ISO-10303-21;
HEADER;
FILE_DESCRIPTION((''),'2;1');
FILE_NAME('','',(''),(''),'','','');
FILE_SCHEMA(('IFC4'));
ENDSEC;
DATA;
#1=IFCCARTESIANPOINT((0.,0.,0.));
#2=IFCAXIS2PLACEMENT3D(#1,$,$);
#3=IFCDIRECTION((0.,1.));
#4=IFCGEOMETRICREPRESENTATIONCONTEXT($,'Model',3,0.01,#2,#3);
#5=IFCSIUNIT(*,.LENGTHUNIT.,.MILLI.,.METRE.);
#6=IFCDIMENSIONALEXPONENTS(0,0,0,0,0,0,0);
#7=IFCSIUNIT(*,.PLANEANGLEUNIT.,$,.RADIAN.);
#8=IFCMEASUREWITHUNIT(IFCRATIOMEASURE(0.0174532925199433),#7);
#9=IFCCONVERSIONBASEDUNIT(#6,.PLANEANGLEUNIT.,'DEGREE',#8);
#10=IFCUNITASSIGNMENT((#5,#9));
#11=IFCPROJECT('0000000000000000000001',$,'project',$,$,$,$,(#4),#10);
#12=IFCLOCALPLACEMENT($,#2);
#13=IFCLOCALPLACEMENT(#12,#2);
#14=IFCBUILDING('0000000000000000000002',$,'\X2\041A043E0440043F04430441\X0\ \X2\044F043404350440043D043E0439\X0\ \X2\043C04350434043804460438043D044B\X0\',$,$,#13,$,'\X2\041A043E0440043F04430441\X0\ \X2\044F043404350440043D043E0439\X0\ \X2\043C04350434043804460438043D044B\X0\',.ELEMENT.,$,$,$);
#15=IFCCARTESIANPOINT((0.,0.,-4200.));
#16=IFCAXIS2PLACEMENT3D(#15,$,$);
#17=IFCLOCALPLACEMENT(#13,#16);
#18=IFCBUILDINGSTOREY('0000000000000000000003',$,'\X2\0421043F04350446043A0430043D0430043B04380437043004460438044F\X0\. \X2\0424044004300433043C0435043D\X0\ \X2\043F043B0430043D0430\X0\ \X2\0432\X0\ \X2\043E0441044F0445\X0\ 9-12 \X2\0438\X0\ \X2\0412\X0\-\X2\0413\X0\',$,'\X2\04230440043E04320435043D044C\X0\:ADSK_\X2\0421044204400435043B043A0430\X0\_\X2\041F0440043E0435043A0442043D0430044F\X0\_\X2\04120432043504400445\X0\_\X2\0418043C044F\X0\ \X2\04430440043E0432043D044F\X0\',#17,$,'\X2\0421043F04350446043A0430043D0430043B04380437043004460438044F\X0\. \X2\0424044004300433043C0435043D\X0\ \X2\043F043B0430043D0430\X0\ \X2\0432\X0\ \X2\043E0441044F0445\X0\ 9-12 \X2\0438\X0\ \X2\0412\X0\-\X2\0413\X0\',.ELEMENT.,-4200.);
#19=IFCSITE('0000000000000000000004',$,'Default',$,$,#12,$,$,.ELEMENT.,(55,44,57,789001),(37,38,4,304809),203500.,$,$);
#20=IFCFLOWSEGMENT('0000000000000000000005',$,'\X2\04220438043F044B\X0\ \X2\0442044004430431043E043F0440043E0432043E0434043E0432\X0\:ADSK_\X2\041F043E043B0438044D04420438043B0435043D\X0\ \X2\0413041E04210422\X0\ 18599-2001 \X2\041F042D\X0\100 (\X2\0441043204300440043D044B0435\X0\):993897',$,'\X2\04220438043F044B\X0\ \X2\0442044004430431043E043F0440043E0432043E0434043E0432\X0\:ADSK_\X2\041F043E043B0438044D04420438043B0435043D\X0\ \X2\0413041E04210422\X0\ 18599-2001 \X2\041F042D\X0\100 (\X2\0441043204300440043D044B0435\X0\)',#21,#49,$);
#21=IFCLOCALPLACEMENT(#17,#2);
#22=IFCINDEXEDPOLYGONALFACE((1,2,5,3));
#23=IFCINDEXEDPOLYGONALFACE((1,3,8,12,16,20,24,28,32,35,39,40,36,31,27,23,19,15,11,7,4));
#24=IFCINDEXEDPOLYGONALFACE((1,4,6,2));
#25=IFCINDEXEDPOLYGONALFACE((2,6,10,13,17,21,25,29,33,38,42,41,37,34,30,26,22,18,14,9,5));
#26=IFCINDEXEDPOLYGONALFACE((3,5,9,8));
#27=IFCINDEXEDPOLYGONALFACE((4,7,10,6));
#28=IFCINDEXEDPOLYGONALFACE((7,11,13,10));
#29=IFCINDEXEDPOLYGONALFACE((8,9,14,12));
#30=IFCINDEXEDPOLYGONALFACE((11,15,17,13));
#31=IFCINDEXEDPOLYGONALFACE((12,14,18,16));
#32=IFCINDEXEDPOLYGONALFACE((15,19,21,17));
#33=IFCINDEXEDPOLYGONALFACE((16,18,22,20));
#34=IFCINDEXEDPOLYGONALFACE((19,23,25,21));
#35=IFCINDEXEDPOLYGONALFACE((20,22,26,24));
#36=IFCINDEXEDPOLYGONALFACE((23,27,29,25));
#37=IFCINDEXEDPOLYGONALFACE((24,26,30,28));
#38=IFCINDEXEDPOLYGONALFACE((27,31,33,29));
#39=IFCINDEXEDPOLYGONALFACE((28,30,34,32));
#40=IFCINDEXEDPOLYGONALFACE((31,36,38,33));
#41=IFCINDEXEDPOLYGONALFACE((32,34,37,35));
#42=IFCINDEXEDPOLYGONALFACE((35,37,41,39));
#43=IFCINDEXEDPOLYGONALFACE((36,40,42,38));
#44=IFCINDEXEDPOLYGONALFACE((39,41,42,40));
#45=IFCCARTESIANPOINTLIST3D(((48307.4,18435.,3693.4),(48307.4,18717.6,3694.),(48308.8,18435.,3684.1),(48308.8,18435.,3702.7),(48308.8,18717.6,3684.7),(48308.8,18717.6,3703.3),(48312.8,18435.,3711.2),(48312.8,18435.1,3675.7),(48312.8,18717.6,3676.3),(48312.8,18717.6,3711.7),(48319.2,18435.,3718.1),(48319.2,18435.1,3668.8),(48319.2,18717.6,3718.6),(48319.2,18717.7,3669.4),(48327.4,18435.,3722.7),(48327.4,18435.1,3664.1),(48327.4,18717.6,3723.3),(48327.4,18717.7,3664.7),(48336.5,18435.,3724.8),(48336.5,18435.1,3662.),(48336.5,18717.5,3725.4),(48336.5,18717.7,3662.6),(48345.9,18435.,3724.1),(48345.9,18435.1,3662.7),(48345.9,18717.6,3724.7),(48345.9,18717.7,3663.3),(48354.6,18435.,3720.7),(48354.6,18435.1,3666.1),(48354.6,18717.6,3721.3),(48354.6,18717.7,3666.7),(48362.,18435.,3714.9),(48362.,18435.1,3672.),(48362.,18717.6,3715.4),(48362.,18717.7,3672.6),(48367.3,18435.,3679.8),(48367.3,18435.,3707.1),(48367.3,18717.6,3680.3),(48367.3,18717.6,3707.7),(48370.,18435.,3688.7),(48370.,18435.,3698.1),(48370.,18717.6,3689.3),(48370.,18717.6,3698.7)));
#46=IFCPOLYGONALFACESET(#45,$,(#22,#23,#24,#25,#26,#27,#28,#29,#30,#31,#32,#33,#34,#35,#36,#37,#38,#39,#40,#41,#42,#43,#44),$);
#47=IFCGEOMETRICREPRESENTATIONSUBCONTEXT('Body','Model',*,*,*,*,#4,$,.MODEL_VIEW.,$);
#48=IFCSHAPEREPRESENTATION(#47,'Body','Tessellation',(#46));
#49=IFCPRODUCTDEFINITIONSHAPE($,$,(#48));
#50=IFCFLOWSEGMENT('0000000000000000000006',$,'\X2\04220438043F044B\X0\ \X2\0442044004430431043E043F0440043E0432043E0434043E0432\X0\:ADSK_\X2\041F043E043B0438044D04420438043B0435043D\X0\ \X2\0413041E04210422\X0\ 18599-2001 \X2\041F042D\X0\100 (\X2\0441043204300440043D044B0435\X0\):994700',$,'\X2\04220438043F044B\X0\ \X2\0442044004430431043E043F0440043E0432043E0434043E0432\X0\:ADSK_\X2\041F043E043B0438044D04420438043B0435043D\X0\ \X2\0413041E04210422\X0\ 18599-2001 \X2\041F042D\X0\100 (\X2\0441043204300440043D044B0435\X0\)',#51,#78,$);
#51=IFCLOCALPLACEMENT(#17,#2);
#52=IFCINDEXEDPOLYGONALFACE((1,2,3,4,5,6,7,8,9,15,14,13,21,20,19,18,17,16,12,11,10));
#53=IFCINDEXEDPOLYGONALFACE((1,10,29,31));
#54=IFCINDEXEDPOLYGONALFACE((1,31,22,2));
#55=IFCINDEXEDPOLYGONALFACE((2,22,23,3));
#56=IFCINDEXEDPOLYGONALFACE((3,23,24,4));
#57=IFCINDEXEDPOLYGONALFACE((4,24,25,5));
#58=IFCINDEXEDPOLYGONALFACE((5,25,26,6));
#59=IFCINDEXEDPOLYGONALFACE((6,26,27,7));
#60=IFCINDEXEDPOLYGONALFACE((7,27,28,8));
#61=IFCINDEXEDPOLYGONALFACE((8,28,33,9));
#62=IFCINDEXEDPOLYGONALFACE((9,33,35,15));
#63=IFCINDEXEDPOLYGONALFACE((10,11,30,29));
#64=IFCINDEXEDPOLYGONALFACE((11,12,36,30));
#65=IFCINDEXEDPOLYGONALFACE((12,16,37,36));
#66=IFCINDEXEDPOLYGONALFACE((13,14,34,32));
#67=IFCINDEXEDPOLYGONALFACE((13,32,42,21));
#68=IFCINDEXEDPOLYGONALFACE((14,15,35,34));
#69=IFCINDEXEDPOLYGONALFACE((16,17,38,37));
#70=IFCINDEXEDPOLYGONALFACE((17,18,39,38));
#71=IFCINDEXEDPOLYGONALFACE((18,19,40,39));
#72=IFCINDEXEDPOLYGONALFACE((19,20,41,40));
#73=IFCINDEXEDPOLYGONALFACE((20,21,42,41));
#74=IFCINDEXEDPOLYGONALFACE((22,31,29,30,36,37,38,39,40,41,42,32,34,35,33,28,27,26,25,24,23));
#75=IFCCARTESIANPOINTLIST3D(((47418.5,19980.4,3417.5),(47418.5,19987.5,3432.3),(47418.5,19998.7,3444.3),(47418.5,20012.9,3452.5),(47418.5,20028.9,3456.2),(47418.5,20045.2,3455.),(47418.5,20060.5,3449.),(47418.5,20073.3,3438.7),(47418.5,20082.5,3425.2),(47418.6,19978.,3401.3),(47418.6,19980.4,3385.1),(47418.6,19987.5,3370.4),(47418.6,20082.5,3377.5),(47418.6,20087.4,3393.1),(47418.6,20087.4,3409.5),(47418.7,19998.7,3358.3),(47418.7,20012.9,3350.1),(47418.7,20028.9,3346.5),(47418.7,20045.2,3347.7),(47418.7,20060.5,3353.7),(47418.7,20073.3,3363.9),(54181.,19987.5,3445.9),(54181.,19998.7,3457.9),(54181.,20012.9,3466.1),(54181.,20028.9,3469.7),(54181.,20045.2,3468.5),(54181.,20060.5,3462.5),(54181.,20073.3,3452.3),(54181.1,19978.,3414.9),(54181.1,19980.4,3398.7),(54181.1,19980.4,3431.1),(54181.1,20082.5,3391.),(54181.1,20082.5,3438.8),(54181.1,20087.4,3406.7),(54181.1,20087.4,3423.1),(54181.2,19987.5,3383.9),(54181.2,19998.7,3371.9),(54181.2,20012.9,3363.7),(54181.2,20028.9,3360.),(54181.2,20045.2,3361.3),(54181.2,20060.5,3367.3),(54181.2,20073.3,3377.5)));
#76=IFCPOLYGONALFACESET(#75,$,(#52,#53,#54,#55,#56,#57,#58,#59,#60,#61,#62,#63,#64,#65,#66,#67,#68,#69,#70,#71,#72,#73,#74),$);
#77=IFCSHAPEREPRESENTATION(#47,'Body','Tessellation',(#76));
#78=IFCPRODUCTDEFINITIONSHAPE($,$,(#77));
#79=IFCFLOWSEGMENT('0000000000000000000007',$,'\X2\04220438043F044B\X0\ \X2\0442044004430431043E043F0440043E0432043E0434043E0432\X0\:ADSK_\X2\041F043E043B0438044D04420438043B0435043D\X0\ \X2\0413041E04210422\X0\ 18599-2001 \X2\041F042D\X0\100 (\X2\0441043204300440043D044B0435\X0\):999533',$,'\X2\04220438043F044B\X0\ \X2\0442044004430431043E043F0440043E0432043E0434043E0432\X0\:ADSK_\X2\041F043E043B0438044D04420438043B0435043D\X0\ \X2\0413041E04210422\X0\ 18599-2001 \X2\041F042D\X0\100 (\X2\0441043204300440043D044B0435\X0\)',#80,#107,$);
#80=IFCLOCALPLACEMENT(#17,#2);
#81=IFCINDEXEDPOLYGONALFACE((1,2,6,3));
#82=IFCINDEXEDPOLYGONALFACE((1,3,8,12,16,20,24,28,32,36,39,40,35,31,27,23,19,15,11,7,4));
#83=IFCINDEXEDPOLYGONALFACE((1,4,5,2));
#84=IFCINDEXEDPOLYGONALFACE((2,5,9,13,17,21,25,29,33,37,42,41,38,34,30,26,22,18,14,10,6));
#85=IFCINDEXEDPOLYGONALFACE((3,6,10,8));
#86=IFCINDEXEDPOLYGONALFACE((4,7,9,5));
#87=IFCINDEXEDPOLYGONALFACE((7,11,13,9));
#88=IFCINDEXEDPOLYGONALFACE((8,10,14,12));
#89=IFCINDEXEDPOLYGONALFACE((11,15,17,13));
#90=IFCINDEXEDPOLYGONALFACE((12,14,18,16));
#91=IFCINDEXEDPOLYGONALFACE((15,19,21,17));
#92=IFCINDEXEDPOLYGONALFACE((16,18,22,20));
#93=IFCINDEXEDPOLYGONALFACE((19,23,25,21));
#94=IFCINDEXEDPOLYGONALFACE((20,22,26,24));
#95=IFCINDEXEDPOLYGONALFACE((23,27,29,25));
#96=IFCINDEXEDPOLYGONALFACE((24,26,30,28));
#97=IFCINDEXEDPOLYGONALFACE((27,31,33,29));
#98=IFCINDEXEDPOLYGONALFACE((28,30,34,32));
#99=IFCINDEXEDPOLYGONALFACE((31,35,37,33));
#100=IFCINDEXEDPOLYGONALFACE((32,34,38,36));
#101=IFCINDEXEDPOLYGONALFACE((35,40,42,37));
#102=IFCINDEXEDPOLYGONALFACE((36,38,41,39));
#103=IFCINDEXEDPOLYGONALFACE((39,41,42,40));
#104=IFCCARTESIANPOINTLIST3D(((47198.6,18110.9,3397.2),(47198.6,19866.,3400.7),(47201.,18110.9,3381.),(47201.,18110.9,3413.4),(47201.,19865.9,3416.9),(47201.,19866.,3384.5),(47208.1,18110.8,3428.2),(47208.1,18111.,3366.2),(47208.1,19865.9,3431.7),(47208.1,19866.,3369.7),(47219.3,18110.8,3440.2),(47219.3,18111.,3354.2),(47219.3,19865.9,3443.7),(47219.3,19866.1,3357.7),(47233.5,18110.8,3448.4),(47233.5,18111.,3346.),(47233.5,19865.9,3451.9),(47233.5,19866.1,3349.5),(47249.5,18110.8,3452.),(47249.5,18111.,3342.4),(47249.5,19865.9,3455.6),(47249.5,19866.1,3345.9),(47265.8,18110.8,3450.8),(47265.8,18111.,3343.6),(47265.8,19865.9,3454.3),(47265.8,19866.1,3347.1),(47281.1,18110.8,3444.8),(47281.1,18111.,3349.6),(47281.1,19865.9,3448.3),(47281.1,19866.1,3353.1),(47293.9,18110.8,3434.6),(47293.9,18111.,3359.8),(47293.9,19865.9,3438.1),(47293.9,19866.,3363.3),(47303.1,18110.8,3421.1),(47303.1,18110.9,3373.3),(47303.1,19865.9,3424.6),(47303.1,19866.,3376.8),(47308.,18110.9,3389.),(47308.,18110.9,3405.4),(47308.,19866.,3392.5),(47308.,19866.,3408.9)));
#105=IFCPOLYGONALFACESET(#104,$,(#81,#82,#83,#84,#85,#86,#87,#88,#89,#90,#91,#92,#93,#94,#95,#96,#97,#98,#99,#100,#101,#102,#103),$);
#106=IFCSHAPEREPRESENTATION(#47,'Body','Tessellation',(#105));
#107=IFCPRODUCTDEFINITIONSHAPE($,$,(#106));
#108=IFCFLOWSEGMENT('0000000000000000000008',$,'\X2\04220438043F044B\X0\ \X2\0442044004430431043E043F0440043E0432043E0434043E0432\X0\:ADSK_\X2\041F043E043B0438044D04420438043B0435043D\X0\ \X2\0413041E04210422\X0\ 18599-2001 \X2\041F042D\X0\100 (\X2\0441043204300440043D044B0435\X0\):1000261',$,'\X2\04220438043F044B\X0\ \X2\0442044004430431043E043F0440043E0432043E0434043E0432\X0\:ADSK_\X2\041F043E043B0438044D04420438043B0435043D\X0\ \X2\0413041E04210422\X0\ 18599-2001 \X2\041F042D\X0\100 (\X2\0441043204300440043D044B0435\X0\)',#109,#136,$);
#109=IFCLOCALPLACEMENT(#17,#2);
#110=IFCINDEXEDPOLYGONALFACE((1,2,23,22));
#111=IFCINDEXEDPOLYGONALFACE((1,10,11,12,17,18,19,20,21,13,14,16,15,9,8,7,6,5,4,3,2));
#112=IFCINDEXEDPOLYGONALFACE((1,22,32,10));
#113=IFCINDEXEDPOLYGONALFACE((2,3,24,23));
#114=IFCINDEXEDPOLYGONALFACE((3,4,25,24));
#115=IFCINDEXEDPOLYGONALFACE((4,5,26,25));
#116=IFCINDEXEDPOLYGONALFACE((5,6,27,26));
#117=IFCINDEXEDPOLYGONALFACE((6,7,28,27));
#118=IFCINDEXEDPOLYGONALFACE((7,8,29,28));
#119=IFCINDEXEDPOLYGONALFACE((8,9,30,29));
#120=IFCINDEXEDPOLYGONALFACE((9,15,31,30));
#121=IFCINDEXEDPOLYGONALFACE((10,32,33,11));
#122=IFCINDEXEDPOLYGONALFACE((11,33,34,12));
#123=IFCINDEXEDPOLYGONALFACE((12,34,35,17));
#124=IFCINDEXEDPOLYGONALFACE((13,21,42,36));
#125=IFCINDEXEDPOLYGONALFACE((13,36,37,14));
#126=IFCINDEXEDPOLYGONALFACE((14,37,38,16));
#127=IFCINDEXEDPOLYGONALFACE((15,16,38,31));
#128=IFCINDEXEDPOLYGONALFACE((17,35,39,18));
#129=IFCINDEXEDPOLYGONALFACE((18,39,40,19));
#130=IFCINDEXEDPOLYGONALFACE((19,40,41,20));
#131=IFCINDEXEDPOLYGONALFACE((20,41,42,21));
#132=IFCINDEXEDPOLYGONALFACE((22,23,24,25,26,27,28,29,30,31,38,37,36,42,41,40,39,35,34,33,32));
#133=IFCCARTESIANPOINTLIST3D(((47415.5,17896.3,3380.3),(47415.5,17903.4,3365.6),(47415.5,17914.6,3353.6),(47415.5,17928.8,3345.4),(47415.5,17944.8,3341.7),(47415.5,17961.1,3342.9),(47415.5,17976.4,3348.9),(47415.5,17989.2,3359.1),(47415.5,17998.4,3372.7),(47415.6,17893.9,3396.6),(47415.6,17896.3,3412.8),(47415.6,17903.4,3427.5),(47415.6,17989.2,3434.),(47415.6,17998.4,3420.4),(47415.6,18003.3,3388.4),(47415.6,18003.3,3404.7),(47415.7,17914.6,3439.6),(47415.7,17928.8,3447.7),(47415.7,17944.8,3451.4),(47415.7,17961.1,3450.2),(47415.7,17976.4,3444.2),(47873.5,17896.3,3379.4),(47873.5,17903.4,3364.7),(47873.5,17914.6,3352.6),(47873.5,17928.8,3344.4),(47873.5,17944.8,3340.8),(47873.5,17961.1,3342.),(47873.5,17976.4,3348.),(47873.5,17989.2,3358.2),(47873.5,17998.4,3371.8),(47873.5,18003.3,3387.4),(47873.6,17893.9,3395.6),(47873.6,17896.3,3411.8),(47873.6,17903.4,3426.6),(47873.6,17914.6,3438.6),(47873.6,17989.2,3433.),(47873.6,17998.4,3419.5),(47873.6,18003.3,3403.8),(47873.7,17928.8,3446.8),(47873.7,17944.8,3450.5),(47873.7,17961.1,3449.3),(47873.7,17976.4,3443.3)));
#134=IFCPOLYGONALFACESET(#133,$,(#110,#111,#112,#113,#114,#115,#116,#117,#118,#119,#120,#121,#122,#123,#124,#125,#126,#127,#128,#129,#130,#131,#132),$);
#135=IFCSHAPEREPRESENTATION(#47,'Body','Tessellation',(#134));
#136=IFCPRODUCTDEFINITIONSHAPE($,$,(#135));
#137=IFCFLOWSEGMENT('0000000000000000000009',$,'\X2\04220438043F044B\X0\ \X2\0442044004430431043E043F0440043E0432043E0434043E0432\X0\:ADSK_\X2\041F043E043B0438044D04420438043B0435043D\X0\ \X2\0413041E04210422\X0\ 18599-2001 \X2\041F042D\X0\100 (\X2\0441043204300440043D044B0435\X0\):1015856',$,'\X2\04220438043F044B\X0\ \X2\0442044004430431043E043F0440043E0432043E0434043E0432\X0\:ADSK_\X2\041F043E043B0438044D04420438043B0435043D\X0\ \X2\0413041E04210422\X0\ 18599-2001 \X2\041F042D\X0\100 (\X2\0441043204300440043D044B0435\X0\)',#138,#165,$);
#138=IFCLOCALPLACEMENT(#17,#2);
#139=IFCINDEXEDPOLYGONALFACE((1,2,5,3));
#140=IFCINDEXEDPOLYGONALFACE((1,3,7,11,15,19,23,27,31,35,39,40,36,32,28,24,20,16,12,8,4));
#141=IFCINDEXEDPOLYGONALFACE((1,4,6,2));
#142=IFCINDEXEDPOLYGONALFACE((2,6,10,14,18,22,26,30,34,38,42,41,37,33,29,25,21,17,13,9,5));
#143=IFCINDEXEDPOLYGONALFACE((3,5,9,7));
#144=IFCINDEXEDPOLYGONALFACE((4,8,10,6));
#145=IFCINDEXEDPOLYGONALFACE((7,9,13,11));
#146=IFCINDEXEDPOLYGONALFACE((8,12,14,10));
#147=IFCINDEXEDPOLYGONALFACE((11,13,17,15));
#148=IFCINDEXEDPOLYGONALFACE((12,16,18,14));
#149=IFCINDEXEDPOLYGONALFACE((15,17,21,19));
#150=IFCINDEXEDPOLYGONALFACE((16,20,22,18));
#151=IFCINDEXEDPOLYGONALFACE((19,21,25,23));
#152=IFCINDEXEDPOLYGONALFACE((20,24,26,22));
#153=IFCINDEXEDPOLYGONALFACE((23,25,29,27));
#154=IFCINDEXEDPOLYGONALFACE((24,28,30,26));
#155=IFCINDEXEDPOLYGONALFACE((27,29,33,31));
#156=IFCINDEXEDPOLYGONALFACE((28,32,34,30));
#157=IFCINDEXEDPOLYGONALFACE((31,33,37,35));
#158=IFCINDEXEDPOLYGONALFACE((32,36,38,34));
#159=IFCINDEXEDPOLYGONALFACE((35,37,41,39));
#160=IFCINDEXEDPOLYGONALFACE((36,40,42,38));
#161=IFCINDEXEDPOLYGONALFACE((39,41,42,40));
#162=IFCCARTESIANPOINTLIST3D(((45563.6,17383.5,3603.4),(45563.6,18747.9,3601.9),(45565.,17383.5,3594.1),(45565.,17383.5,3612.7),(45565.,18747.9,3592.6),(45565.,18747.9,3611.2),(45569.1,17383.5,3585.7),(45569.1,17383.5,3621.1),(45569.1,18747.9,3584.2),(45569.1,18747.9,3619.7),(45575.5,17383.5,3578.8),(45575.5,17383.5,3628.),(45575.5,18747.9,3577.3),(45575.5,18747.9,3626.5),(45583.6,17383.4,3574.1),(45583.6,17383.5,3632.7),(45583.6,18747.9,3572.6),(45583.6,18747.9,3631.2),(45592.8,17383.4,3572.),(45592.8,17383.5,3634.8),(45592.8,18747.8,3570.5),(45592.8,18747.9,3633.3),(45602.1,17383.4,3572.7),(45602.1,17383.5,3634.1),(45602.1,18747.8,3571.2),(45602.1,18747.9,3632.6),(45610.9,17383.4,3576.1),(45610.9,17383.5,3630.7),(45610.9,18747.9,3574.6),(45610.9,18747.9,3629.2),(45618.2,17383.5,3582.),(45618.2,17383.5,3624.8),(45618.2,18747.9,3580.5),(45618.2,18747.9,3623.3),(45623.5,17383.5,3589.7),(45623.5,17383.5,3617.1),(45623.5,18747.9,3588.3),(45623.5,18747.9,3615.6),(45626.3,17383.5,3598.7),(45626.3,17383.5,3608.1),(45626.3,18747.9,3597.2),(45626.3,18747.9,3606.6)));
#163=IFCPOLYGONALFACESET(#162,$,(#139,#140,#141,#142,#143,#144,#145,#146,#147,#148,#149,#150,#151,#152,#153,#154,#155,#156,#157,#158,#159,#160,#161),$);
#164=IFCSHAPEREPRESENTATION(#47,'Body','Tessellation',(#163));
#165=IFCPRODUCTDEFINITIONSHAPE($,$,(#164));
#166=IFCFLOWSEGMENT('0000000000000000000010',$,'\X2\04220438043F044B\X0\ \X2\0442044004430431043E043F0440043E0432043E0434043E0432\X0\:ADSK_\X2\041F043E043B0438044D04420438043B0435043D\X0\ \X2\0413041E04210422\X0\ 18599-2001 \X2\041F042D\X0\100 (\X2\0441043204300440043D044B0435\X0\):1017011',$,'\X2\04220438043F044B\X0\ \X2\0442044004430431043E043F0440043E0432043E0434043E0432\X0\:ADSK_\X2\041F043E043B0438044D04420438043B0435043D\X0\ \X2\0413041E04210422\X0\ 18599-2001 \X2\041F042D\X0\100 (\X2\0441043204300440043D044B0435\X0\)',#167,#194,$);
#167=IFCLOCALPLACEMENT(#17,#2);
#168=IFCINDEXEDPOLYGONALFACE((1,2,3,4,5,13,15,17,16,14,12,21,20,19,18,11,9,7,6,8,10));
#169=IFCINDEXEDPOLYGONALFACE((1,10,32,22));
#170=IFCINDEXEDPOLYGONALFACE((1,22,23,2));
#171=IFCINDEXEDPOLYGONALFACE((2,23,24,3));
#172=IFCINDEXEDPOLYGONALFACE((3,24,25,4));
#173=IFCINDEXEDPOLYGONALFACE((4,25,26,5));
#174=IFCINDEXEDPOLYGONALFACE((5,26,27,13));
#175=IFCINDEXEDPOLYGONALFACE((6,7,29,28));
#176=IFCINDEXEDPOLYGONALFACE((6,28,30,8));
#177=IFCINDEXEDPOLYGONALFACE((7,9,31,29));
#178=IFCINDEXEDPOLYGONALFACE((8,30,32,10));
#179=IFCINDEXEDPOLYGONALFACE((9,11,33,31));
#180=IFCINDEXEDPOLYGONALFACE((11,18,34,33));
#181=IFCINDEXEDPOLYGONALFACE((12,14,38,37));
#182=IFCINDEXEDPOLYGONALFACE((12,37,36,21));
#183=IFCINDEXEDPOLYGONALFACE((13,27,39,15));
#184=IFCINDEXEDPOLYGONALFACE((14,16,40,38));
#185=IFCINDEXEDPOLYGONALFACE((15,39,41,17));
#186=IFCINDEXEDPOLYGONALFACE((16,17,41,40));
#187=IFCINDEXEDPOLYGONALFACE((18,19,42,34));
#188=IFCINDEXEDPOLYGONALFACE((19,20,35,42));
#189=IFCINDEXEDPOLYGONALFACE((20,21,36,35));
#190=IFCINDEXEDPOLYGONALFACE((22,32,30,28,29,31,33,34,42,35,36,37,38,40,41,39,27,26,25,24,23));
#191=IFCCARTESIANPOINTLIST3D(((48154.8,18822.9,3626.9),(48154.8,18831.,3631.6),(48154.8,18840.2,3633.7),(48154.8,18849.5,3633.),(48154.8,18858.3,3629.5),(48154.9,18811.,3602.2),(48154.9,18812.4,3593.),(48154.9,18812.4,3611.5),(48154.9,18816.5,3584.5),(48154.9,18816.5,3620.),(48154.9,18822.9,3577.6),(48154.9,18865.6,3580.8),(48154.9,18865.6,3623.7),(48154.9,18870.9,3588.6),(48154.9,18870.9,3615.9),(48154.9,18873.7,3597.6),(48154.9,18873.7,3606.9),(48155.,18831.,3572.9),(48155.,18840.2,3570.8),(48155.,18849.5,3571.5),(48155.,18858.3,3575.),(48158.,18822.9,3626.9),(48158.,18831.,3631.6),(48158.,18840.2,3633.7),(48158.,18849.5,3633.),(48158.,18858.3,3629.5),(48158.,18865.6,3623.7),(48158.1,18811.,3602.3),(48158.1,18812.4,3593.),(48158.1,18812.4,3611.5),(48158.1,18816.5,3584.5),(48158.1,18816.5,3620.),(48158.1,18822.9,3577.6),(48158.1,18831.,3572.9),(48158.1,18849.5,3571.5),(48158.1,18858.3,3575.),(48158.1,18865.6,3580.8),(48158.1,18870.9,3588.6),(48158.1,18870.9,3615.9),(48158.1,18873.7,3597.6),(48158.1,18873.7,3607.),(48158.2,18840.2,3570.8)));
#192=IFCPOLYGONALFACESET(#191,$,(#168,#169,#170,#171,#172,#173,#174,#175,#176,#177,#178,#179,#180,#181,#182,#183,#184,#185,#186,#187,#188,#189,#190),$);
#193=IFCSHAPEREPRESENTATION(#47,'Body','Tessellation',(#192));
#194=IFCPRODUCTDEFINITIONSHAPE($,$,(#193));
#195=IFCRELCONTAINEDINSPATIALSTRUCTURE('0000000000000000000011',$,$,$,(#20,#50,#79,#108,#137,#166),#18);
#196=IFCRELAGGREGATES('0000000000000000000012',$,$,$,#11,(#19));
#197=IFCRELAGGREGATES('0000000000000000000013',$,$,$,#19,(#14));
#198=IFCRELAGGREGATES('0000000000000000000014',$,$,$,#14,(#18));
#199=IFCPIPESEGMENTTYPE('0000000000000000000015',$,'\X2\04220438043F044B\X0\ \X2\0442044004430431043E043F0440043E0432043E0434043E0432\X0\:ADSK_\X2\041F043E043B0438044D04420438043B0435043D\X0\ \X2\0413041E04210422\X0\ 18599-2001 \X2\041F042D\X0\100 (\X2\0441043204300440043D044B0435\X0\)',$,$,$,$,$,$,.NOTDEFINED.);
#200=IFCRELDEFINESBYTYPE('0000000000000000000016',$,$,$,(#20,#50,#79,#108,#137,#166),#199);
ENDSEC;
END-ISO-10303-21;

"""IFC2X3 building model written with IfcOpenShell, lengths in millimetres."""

from ifc_helpers import new_model, entity, si_unit, converted_unit, direction, frame, frame_2d, origin, origin_2d_with_axis, place, context, subcontext, project, spatial, circle, extrude, type_object, element, save


model = new_model("IFC2X3")

# Units and contexts
model_context = context("Model", 3, precision=0.01, world=origin(), true_north=direction((0.0, 1.0)))
body_context = subcontext(model_context, "Body", "Model", "MODEL_VIEW")
ifc_project = project(units=[si_unit("LENGTHUNIT", "METRE", prefix="MILLI"), converted_unit("PLANEANGLEUNIT", "DEGREE", entity("IfcRatioMeasure", 0.0174532925199433), si_unit("PLANEANGLEUNIT", "RADIAN"), dimensions=[0, 0, 0, 0, 0, 0, 0])], contexts=[model_context])

# Site, building, storey
site_placement = place(None, frame((0.0, 0.0, 0.0)))
site = spatial("IfcSite", under=ifc_project, at=site_placement, Name="Default", CompositionType="ELEMENT", RefLatitude=(55, 44, 57, 789001), RefLongitude=(37, 38, 4, 304809), RefElevation=203500.0)
building_placement = place(site_placement, origin())
building = spatial("IfcBuilding", under=site, at=building_placement, Name="Корпус ядерной медицины", LongName="Корпус ядерной медицины", CompositionType="ELEMENT")
storey_placement = place(building_placement, frame((0.0, 0.0, -4200.0)))
storey = spatial("IfcBuildingStorey", under=building, at=storey_placement, Name="Спецканализация. Фрагмен плана в осях 9-12 и В-Г", ObjectType="Уровень:ADSK_Стрелка_Проектная_Вверх_Имя уровня", LongName="Спецканализация. Фрагмен плана в осях 9-12 и В-Г", CompositionType="ELEMENT", Elevation=-4200.0)

# Flow segments
pipe_segment_type = type_object("IfcPipeSegmentType", Name="Типы трубопроводов:ADSK_Полиэтилен ГОСТ 18599-2001 ПЭ100 (сварные)", PredefinedType="NOTDEFINED")
flow_segment_1_placement = place(storey_placement, frame((48305.8, 18435.0, 3660.3)))
element("IfcFlowSegment", 1, at=flow_segment_1_placement, inside=storey, type_object=pipe_segment_type, Name="Типы трубопроводов:ADSK_Полиэтилен ГОСТ 18599-2001 ПЭ100 (сварные):993897", ObjectType="Типы трубопроводов:ADSK_Полиэтилен ГОСТ 18599-2001 ПЭ100 (сварные)", context=body_context, shape_type="SweptSolid", body=[
    extrude(circle(Radius=31.5, at=frame_2d((0.0, 0.0), x_axis=(1.0, 0.0))), frame((33.1, 0.1, 33.1), z_axis=(-0.000004, 0.999998, 0.002042), x_axis=(-1.0, -0.000004, 0.0)), (0.0, 0.0, 1.0), 282.6),
])
flow_segment_2_placement = place(storey_placement, frame((47418.5, 19976.4, 3344.7)))
element("IfcFlowSegment", 2, at=flow_segment_2_placement, inside=storey, type_object=pipe_segment_type, Name="Типы трубопроводов:ADSK_Полиэтилен ГОСТ 18599-2001 ПЭ100 (сварные):994700", ObjectType="Типы трубопроводов:ADSK_Полиэтилен ГОСТ 18599-2001 ПЭ100 (сварные)", context=body_context, shape_type="SweptSolid", body=[
    extrude(circle(Radius=55.0, at=origin_2d_with_axis()), frame((0.1, 56.6, 56.6), z_axis=(0.999998, 0.0, 0.002004), x_axis=(0.0, -1.0, 0.0)), (0.0, 0.0, 1.0), 6762.5),
])
flow_segment_3_placement = place(storey_placement, frame((47197.0, 18110.8, 3340.6)))
element("IfcFlowSegment", 3, at=flow_segment_3_placement, inside=storey, type_object=pipe_segment_type, Name="Типы трубопроводов:ADSK_Полиэтилен ГОСТ 18599-2001 ПЭ100 (сварные):999533", ObjectType="Типы трубопроводов:ADSK_Полиэтилен ГОСТ 18599-2001 ПЭ100 (сварные)", context=body_context, shape_type="SweptSolid", body=[
    extrude(circle(Radius=55.0, at=origin_2d_with_axis()), frame((56.6, 0.1, 56.6), z_axis=(0.000001, 0.999998, 0.002), x_axis=(-1.0, 0.000001, 0.0)), (0.0, 0.0, 1.0), 1755.1),
])
flow_segment_4_placement = place(storey_placement, frame((47415.5, 17892.3, 3339.0)))
element("IfcFlowSegment", 4, at=flow_segment_4_placement, inside=storey, type_object=pipe_segment_type, Name="Типы трубопроводов:ADSK_Полиэтилен ГОСТ 18599-2001 ПЭ100 (сварные):1000261", ObjectType="Типы трубопроводов:ADSK_Полиэтилен ГОСТ 18599-2001 ПЭ100 (сварные)", context=body_context, shape_type="SweptSolid", body=[
    extrude(circle(Radius=55.0, at=frame_2d((0.0, 0.0), x_axis=(1.0, 0.0))), frame((0.1, 56.6, 57.5), z_axis=(0.999998, 0.0, -0.002), x_axis=(0.0, -1.0, 0.0)), (0.0, 0.0, 1.0), 458.0),
])
flow_segment_5_placement = place(storey_placement, frame((45562.0, 17383.4, 3568.8)))
element("IfcFlowSegment", 5, at=flow_segment_5_placement, inside=storey, type_object=pipe_segment_type, Name="Типы трубопроводов:ADSK_Полиэтилен ГОСТ 18599-2001 ПЭ100 (сварные):1015856", ObjectType="Типы трубопроводов:ADSK_Полиэтилен ГОСТ 18599-2001 ПЭ100 (сварные)", context=body_context, shape_type="SweptSolid", body=[
    extrude(circle(Radius=31.5, at=frame_2d((0.0, 0.0), x_axis=(1.0, 0.0))), frame((33.1, 1364.4, 33.1), z_axis=(0.0, -0.999999, 0.001085), x_axis=(-1.0, 0.0, 0.0)), (0.0, 0.0, 1.0), 1364.4),
])
flow_segment_6_placement = place(storey_placement, frame((48154.8, 18809.4, 3569.2)))
element("IfcFlowSegment", 6, at=flow_segment_6_placement, inside=storey, type_object=pipe_segment_type, Name="Типы трубопроводов:ADSK_Полиэтилен ГОСТ 18599-2001 ПЭ100 (сварные):1017011", ObjectType="Типы трубопроводов:ADSK_Полиэтилен ГОСТ 18599-2001 ПЭ100 (сварные)", context=body_context, shape_type="SweptSolid", body=[
    extrude(circle(Radius=31.5, at=frame_2d((0.0, 0.0), x_axis=(1.0, 0.0))), frame((0.1, 33.1, 33.1), z_axis=(0.999998, 0.0, 0.002), x_axis=(0.0, -1.0, 0.0)), (0.0, 0.0, 1.0), 3.2),
])

save(model, "model.ifc")
